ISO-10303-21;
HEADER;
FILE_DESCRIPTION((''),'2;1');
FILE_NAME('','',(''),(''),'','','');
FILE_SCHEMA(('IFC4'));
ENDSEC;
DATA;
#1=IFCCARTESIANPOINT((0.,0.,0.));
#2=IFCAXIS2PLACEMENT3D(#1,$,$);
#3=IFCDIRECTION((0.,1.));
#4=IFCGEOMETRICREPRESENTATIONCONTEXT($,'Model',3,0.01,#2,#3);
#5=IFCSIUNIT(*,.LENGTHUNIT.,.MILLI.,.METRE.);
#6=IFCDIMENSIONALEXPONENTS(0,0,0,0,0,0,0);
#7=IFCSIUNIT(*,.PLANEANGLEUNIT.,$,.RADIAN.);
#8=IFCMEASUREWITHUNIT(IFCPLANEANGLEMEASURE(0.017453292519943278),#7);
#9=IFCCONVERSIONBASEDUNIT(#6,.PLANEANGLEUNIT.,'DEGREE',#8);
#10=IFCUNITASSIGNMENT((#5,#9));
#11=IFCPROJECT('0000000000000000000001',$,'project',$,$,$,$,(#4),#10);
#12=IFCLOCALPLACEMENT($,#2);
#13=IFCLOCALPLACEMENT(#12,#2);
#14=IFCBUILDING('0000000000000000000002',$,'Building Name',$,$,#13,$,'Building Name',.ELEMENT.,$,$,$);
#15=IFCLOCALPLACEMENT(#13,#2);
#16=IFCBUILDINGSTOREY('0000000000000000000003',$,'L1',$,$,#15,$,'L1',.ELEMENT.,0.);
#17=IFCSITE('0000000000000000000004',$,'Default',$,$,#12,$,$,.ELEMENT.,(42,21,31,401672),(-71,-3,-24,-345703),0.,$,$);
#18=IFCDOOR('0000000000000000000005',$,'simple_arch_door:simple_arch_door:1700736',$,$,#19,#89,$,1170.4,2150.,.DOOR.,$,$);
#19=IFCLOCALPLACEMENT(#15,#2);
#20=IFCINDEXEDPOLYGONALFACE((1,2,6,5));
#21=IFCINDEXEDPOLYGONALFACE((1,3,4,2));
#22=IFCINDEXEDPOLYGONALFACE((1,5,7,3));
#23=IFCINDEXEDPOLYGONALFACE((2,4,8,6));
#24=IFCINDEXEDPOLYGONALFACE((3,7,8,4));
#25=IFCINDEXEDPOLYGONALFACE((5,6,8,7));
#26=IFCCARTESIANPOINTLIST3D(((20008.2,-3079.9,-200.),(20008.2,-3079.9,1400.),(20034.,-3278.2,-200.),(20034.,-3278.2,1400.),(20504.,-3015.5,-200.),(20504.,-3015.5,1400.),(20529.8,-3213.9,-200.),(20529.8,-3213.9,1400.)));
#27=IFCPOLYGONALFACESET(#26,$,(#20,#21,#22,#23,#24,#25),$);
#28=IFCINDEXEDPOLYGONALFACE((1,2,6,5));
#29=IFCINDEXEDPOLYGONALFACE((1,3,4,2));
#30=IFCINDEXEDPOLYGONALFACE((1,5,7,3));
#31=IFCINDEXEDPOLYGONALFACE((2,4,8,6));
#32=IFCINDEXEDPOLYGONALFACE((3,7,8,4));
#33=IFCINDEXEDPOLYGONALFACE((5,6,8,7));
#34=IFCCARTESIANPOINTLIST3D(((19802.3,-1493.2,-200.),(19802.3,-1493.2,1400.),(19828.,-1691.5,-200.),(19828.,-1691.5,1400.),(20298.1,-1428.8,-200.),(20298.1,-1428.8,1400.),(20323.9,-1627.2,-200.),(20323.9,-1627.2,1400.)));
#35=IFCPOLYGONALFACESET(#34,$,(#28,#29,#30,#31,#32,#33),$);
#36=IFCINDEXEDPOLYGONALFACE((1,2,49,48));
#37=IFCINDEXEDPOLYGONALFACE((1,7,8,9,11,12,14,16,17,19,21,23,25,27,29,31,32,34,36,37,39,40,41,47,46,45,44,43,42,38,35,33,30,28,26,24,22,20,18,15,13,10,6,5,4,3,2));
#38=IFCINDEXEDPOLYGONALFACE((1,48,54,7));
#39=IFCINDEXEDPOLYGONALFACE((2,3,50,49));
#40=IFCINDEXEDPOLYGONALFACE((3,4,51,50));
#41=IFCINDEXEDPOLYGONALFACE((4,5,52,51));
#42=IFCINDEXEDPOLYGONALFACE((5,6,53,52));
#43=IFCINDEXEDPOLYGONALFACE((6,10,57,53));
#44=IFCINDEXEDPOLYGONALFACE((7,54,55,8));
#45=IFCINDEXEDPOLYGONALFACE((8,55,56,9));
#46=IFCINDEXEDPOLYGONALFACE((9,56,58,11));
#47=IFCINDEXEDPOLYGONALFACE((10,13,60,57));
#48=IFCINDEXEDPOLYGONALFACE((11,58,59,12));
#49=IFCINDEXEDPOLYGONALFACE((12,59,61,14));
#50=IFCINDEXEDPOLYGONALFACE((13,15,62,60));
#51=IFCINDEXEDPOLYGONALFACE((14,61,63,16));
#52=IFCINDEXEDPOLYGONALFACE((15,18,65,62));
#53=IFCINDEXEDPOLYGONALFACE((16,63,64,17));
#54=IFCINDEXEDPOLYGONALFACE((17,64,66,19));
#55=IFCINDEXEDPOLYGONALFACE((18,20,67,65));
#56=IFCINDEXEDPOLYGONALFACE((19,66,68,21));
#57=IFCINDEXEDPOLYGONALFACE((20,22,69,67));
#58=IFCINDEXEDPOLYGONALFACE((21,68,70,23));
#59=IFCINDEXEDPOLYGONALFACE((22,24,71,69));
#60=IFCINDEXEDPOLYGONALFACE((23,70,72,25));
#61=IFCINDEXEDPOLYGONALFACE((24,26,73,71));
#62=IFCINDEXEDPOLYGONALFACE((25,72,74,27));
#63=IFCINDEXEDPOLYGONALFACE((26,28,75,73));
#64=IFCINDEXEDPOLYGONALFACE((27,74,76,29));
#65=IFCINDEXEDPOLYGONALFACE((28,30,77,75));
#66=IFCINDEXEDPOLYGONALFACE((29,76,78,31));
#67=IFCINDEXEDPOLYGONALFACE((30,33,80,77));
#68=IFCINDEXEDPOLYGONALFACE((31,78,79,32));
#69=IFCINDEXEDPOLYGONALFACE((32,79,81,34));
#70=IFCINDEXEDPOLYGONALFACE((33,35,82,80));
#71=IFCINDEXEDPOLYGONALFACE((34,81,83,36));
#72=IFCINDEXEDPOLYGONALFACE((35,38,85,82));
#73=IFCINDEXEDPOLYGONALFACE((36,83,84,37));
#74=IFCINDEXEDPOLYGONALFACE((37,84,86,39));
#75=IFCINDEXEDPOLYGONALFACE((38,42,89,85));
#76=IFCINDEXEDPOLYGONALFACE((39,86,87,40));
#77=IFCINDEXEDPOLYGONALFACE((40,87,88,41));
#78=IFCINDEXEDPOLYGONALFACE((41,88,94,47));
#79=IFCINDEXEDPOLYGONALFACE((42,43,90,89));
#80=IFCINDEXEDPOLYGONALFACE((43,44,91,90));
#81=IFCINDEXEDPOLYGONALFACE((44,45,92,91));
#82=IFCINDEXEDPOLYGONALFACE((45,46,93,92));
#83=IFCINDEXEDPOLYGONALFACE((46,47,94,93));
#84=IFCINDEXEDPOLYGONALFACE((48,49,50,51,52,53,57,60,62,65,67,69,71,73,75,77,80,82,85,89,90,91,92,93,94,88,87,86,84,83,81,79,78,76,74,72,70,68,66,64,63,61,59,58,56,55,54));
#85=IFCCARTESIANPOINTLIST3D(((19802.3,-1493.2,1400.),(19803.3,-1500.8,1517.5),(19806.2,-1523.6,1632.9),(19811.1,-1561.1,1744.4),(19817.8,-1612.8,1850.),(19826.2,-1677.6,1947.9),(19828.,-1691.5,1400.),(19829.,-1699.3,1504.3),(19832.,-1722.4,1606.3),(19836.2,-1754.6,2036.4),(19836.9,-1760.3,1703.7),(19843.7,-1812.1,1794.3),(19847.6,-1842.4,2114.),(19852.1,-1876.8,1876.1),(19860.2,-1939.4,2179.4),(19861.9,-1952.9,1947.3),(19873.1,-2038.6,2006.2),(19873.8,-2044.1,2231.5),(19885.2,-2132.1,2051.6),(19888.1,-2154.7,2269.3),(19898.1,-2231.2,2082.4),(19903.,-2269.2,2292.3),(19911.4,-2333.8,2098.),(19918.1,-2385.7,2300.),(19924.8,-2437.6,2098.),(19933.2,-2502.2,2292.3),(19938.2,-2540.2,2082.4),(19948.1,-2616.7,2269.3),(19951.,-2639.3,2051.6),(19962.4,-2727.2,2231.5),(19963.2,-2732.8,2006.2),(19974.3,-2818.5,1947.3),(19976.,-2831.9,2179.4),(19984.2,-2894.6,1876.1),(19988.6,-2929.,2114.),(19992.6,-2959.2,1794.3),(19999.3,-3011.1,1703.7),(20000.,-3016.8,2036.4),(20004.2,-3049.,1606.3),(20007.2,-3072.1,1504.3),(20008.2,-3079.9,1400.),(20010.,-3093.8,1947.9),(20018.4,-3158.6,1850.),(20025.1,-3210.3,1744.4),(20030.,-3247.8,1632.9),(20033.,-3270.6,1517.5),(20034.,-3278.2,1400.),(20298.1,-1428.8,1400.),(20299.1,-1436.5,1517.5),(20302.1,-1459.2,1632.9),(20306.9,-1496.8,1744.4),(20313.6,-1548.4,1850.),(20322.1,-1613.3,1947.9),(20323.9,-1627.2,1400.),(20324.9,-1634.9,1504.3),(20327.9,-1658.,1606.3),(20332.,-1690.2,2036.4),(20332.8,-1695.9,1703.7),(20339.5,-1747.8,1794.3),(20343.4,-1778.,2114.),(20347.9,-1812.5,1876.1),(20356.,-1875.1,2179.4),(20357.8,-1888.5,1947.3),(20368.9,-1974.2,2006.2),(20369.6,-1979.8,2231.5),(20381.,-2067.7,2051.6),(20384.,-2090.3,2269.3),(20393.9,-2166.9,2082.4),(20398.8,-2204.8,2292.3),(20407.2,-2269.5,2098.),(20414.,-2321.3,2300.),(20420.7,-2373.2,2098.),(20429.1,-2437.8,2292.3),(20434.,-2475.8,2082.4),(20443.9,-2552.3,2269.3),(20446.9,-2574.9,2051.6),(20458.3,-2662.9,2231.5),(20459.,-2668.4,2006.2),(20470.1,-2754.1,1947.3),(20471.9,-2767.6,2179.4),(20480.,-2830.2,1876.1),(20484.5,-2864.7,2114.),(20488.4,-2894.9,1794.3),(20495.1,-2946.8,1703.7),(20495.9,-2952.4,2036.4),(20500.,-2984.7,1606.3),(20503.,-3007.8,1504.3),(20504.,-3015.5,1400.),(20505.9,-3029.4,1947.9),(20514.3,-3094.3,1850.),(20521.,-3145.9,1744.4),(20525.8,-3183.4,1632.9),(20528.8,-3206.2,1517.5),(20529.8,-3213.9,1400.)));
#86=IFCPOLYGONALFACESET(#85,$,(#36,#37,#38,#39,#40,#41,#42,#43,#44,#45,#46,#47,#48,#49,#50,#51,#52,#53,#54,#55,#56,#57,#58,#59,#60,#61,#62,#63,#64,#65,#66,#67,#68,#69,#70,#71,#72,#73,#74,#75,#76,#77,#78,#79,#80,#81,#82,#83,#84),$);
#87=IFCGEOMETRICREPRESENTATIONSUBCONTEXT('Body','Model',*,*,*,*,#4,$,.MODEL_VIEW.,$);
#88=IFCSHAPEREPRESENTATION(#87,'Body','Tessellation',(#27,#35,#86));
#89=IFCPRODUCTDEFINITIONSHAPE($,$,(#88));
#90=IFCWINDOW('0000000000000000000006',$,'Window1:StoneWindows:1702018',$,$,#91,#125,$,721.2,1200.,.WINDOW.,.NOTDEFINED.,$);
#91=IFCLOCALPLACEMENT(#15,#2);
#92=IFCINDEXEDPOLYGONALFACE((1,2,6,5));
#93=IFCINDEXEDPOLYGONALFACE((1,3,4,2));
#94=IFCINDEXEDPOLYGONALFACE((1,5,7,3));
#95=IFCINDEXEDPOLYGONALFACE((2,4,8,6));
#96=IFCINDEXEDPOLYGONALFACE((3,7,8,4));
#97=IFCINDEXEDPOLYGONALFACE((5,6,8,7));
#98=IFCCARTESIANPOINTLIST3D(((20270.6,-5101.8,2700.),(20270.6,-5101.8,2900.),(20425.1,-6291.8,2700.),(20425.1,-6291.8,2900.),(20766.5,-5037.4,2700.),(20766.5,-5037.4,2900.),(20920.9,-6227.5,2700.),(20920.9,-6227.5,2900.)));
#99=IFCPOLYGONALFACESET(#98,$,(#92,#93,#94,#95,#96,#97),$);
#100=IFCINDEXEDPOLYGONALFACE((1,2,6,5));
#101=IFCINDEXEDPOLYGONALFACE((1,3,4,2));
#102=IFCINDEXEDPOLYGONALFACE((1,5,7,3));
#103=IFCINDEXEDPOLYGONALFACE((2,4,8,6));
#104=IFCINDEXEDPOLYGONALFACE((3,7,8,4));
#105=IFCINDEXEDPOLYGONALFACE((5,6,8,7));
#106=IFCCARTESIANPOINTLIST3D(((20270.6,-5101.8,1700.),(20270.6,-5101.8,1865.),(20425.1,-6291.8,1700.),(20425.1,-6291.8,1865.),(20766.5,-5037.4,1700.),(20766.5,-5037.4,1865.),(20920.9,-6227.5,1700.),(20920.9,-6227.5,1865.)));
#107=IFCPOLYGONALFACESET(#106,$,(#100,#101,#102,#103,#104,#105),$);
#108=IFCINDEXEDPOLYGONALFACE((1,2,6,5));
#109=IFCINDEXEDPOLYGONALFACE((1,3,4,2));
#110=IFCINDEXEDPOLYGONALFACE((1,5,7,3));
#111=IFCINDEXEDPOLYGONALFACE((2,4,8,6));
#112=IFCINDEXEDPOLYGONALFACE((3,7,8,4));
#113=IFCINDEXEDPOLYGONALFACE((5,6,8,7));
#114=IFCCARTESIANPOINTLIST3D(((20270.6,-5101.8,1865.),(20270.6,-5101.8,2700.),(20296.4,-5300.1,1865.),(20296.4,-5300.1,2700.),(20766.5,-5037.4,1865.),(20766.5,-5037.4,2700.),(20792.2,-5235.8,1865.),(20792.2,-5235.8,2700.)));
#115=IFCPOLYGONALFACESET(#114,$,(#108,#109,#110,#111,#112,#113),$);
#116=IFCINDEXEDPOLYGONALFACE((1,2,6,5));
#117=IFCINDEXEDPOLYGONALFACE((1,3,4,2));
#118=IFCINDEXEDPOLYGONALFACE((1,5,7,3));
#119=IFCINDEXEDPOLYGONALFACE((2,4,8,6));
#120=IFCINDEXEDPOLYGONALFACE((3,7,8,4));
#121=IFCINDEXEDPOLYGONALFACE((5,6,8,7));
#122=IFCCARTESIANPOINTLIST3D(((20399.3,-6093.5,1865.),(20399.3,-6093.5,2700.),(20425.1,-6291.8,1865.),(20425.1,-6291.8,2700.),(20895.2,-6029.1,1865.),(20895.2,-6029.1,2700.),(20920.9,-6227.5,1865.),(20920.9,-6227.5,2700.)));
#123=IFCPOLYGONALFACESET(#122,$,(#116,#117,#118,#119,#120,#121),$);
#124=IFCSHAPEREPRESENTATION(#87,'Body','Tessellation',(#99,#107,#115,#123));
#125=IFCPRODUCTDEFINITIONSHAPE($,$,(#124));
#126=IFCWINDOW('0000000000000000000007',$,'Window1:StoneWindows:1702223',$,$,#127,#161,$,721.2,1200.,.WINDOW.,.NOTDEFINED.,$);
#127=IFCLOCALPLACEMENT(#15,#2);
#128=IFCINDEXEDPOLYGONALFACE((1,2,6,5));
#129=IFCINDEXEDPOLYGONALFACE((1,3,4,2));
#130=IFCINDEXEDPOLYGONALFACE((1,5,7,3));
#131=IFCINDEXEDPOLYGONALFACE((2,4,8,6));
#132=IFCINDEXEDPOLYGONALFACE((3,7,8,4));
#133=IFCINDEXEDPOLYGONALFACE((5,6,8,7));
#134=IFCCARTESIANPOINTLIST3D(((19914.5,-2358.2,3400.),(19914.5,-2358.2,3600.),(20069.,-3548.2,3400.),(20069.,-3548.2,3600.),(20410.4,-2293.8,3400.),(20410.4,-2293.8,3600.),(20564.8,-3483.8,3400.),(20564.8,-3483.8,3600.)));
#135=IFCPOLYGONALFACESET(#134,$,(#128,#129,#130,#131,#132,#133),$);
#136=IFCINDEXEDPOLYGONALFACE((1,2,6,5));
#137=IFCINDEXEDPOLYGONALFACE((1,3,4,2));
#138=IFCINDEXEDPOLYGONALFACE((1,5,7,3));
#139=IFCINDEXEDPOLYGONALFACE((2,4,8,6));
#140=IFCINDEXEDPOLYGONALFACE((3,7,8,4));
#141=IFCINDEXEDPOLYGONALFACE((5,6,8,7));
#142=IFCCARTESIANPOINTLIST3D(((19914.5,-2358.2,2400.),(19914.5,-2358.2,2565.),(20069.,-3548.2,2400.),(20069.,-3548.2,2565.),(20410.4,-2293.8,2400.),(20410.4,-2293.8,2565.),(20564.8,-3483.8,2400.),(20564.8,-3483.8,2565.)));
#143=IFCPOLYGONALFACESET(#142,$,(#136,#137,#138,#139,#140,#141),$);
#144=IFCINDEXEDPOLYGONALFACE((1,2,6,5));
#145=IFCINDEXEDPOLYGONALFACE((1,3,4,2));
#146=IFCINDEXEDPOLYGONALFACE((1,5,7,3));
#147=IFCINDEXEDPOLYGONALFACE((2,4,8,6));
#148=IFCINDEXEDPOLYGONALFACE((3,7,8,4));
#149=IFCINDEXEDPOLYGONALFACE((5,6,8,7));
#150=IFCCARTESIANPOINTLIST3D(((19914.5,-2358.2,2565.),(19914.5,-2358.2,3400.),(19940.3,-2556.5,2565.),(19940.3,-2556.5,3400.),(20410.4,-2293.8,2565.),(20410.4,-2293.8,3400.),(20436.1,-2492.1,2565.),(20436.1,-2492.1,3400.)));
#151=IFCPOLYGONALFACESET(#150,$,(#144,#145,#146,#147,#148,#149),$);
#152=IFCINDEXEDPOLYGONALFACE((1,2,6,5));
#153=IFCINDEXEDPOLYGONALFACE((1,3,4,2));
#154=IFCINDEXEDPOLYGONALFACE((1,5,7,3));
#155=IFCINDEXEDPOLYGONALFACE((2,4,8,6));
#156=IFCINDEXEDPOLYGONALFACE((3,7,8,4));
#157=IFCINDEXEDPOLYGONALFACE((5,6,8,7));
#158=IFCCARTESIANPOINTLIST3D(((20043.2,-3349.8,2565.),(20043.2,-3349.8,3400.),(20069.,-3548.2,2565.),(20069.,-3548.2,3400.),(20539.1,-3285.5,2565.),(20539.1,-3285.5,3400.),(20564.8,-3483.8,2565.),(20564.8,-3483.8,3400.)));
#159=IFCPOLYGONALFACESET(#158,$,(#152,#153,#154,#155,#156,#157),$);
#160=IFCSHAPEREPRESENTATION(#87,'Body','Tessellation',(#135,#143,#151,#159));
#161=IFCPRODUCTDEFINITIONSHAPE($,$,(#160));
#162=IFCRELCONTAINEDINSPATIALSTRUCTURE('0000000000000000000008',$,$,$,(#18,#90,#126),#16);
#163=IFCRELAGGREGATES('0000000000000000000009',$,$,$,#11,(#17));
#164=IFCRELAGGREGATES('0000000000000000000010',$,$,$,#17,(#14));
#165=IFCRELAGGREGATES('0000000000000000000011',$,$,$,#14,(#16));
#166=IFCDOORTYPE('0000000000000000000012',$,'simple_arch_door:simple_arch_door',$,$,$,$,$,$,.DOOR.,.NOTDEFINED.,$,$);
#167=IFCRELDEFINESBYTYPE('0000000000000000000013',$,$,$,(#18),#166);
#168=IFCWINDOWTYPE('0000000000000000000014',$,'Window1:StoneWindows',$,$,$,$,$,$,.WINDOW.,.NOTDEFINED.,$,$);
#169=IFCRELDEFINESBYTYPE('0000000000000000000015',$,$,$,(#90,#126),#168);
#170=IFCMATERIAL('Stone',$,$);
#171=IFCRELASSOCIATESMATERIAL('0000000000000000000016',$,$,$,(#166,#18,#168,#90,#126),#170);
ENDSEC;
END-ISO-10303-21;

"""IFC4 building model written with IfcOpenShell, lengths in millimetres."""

from ifc_helpers import new_model, entity, si_unit, converted_unit, direction, frame, origin, place, context, subcontext, project, spatial, line, arc, indexed_curve, outline, extrude, source, transform, mapped, material, type_object, type_shapes, element, save


model = new_model("IFC4")

# Units and contexts
model_context = context("Model", 3, precision=0.01, world=origin(), true_north=direction((0.0, 1.0)))
body_context = subcontext(model_context, "Body", "Model", "MODEL_VIEW")
ifc_project = project(units=[si_unit("LENGTHUNIT", "METRE", prefix="MILLI"), converted_unit("PLANEANGLEUNIT", "DEGREE", entity("IfcPlaneAngleMeasure", 0.017453292519943278), si_unit("PLANEANGLEUNIT", "RADIAN"), dimensions=[0, 0, 0, 0, 0, 0, 0])], contexts=[model_context])

# Site, building, storey
site_placement = place(None, origin())
site = spatial("IfcSite", under=ifc_project, at=site_placement, Name="Default", CompositionType="ELEMENT", RefLatitude=(42, 21, 31, 401672), RefLongitude=(-71, -3, -24, -345703), RefElevation=0.0)
building_placement = place(site_placement, origin())
building = spatial("IfcBuilding", under=site, at=building_placement, Name="Building Name", LongName="Building Name", CompositionType="ELEMENT")
storey_placement = place(building_placement, origin())
storey = spatial("IfcBuildingStorey", under=building, at=storey_placement, Name="L1", LongName="L1", CompositionType="ELEMENT", Elevation=0.0)

# Door
ifc_material_1 = material(Name="Stone")
door_type_1 = type_object("IfcDoorType", Name="simple_arch_door:simple_arch_door", OperationType="NOTDEFINED", PredefinedType="DOOR", material=ifc_material_1)
shared_shape_1 = source(origin(), body_context, "Body", "SweptSolid", [
    extrude(outline(indexed_curve([(-250.0, -100.0), (250.0, -100.0), (250.0, 100.0), (-250.0, 100.0), (-250.0, -100.0)], self_intersect=False)), frame((800.0, 0.0, 0.0), z_axis=(0.0, 0.0, 1.0), x_axis=(0.0, 1.0, 0.0)), (0.0, 0.0, 1.0), 1600.0),
    extrude(outline(indexed_curve([(-250.0, -100.0), (250.0, -100.0), (250.0, 100.0), (-250.0, 100.0), (-250.0, -100.0)], self_intersect=False)), frame((-800.0, 0.0, 0.0), z_axis=(0.0, 0.0, 1.0), x_axis=(0.0, 1.0, 0.0)), (0.0, 0.0, 1.0), 1600.0),
    extrude(outline(indexed_curve([(-900.0, 0.0), (0.0, -900.0), (900.0, 0.0), (700.0, 0.0), (0.0, -700.0), (-700.0, 0.0)], segments=[arc(1, 2, 3), line(3, 4), arc(4, 5, 6), line(6, 1)], self_intersect=False)), frame((0.0, -250.0, 1600.0), z_axis=(0.0, 1.0, 0.0), x_axis=(1.0, 0.0, 0.0)), (0.0, 0.0, 1.0), 500.0),
])
type_shapes(door_type_1, [shared_shape_1])
door_1_placement = place(storey_placement, frame((20166.0, -2353.5, -200.0), z_axis=(0.0, 0.0, 1.0), x_axis=(0.128709, -0.991682, 0.0)))
element("IfcDoor", 1, at=door_1_placement, inside=storey, type_object=door_type_1, material=ifc_material_1, Name="simple_arch_door:simple_arch_door:1700736", OverallHeight=1170.4, OverallWidth=2150.0, PredefinedType="DOOR", context=body_context, shape_type="MappedRepresentation", body=[
    mapped(shared_shape_1, transform((0.0, 0.0, 0.0), scale=1.0)),
])

# Windows
window_type = type_object("IfcWindowType", Name="Window1:StoneWindows", PartitioningType="NOTDEFINED", PredefinedType="WINDOW", material=ifc_material_1)
shared_shape_2 = source(origin(), body_context, "Body", "SweptSolid", [
    extrude(outline(indexed_curve([(-250.0, -600.0), (250.0, -600.0), (250.0, 600.0), (-250.0, 600.0), (-250.0, -600.0)], self_intersect=False)), frame((0.0, 0.0, 1800.0), z_axis=(0.0, 0.0, 1.0), x_axis=(0.0, 1.0, 0.0)), (0.0, 0.0, 1.0), 200.0),
    extrude(outline(indexed_curve([(-250.0, -600.0), (250.0, -600.0), (250.0, 600.0), (-250.0, 600.0), (-250.0, -600.0)], self_intersect=False)), frame((0.0, 0.0, 800.0), z_axis=(0.0, 0.0, 1.0), x_axis=(0.0, 1.0, 0.0)), (0.0, 0.0, 1.0), 165.0),
    extrude(outline(indexed_curve([(-250.0, -100.0), (250.0, -100.0), (250.0, 100.0), (-250.0, 100.0), (-250.0, -100.0)], self_intersect=False)), frame((-500.0, 0.0, 965.0), z_axis=(0.0, 0.0, 1.0), x_axis=(0.0, 1.0, 0.0)), (0.0, 0.0, 1.0), 835.0),
    extrude(outline(indexed_curve([(-250.0, -100.0), (250.0, -100.0), (250.0, 100.0), (-250.0, 100.0), (-250.0, -100.0)], self_intersect=False)), frame((500.0, 0.0, 965.0), z_axis=(0.0, 0.0, 1.0), x_axis=(0.0, 1.0, 0.0)), (0.0, 0.0, 1.0), 835.0),
])
type_shapes(window_type, [shared_shape_2])
for number, where, z_axis, x_axis, name in (
    (2, (20595.8, -5664.6, 900.0), (0.0, 0.0, 1.0), (0.128709, -0.991682, 0.0), "Window1:StoneWindows:1702018"),
    (3, (20239.7, -2921.0, 1600.0), (0.0, 0.0, 1.0), (0.128709, -0.991682, 0.0), "Window1:StoneWindows:1702223"),
):
    element("IfcWindow", number, at=place(storey_placement, frame(where, z_axis=z_axis, x_axis=x_axis)), inside=storey, type_object=window_type, material=ifc_material_1, Name=name, OverallHeight=721.2, OverallWidth=1200.0, PartitioningType="NOTDEFINED", PredefinedType="WINDOW", context=body_context, shape_type="MappedRepresentation", body=[
        mapped(shared_shape_2, transform((0.0, 0.0, 0.0), scale=1.0)),
    ])

save(model, "model.ifc")
